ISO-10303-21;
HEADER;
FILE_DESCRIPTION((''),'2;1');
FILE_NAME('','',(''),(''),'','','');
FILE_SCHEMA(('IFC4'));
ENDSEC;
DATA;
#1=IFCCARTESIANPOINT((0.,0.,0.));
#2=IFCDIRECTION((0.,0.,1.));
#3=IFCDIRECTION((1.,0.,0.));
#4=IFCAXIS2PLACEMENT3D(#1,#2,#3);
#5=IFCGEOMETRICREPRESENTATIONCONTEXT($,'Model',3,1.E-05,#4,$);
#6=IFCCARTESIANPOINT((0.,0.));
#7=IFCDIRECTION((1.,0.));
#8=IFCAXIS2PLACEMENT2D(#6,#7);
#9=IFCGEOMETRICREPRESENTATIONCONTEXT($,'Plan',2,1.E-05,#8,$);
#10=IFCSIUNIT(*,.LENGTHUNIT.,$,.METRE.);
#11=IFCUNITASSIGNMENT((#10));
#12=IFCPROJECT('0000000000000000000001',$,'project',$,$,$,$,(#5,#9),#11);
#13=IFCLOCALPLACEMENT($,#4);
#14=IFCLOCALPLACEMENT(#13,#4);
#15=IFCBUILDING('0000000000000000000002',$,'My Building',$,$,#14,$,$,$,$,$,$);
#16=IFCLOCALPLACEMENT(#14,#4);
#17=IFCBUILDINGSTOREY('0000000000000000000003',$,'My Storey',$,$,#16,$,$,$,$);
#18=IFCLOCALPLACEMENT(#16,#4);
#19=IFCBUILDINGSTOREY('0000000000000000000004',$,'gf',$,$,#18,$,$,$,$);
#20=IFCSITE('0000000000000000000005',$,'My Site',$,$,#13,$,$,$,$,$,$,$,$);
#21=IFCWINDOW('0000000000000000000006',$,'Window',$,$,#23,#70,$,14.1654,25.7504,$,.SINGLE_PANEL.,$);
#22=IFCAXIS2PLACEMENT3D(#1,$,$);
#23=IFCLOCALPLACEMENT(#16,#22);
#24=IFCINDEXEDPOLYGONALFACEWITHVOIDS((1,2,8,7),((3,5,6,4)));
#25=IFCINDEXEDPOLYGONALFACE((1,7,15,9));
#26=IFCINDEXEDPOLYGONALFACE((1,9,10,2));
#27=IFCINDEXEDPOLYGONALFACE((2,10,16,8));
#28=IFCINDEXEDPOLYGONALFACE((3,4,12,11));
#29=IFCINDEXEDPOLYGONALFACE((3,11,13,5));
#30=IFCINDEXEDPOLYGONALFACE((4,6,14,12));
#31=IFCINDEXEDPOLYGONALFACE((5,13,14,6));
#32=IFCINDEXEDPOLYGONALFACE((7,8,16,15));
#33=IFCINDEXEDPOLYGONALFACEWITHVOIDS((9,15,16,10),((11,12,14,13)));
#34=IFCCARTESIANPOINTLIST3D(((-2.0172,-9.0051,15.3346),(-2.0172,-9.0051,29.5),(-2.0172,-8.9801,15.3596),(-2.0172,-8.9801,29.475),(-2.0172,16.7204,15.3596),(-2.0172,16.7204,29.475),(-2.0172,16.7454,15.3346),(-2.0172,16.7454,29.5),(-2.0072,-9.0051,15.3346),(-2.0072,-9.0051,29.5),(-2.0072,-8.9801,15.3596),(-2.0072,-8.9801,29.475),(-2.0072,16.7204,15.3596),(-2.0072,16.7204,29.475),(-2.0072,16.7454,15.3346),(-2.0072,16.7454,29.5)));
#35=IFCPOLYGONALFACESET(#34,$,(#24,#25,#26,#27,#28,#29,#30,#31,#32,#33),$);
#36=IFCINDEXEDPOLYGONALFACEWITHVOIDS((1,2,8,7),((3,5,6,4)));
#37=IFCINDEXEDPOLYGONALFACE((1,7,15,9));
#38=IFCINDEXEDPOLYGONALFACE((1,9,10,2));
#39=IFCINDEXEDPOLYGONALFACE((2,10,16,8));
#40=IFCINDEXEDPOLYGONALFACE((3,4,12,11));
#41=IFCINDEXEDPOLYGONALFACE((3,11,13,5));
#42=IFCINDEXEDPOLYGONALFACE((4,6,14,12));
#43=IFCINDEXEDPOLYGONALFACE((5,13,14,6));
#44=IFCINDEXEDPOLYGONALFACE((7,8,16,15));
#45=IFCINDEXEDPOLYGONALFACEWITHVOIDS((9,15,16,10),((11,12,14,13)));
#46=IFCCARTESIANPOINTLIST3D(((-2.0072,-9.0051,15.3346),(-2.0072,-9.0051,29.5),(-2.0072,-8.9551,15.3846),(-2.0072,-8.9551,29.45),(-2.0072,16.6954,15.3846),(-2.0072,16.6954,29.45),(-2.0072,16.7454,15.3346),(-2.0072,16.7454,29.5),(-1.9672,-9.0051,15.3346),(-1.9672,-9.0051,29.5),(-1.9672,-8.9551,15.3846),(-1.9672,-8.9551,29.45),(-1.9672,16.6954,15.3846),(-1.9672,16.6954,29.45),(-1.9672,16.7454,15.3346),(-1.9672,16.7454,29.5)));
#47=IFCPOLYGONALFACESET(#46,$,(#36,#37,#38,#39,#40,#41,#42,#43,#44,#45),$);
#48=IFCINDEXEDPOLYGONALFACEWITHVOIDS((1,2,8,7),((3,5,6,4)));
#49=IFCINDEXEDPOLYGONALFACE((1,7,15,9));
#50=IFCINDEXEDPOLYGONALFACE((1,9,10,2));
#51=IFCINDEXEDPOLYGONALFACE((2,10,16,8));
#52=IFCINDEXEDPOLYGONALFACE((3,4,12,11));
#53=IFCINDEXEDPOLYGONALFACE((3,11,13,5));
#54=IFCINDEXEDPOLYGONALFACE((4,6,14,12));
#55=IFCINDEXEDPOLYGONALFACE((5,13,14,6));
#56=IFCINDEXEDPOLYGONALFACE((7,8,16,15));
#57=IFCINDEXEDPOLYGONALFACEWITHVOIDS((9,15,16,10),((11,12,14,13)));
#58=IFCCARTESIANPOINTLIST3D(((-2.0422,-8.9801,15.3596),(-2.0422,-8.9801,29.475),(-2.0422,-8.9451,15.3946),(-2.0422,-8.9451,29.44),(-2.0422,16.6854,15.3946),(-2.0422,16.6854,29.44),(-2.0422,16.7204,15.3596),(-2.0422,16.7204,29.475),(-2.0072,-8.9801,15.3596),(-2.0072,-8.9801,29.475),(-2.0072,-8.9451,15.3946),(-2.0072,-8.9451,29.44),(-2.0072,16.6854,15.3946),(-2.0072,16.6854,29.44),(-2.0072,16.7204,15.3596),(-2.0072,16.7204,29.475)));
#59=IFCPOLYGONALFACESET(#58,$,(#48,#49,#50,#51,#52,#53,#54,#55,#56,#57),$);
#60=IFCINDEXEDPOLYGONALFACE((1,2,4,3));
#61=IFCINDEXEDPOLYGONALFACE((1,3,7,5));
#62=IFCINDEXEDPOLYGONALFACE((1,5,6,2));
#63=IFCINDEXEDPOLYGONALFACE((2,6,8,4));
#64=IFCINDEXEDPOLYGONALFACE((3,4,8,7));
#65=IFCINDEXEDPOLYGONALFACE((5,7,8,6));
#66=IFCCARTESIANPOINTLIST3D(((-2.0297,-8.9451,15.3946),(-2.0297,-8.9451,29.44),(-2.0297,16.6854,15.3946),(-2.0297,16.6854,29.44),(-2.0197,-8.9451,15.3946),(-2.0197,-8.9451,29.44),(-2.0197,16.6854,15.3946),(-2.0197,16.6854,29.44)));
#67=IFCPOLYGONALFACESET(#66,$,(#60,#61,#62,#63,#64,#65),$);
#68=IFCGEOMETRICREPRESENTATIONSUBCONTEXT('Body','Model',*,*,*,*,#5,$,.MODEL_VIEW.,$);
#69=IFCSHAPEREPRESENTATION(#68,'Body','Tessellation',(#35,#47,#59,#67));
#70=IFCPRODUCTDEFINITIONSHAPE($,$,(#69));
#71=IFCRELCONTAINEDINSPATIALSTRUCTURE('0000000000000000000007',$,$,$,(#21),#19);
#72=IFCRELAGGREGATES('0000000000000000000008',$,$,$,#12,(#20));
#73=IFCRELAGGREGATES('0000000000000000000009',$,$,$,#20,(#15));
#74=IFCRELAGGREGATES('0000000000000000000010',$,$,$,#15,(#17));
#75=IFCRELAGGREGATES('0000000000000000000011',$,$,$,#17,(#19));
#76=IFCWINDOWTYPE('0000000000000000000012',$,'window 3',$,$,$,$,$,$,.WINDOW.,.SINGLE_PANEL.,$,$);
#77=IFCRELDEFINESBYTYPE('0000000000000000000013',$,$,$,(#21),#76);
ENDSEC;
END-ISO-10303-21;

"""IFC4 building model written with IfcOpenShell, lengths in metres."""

from ifc_helpers import new_model, entity, si_unit, frame, origin_with_axes, origin_2d_with_axis, place, context, subcontext, project, spatial, line, indexed_curve, outline, extrude, shape, source, transform, mapped, type_object, type_shapes, element, save


model = new_model("IFC4")

# Units and contexts
model_context = context("Model", 3, precision=1e-05, world=origin_with_axes())
plan_context = context("Plan", 2, precision=1e-05, world=origin_2d_with_axis())
body_context_1 = subcontext(model_context, "Body", "Model", "MODEL_VIEW")
body_context_2 = subcontext(plan_context, "Body", "Plan", "PLAN_VIEW")
ifc_project = project(units=[si_unit("LENGTHUNIT", "METRE")], contexts=[model_context, plan_context])

# Site, building, storeys
site_placement = place(None, origin_with_axes())
site = spatial("IfcSite", under=ifc_project, at=site_placement, Name="My Site")
building_placement = place(site_placement, origin_with_axes())
building = spatial("IfcBuilding", under=site, at=building_placement, Name="My Building")
storey_1_placement = place(building_placement, origin_with_axes())
storey_1 = spatial("IfcBuildingStorey", under=building, at=storey_1_placement, Name="My Storey")
storey_2_placement = place(storey_1_placement, origin_with_axes())
storey_2 = spatial("IfcBuildingStorey", under=storey_1, at=storey_2_placement, Name="gf")

# Window
window_type_1 = type_object("IfcWindowType", Name="window 3", PartitioningType="SINGLE_PANEL", PredefinedType="WINDOW")
shared_shape_1 = source(origin_with_axes(), body_context_1, "Body", "SweptSolid", [
    extrude(outline(indexed_curve([(0.0, 0.0), (25.7504, 0.0), (25.7504, 14.1654), (0.0, 14.1654)], segments=[line(1, 2, 3, 4, 1)]), holes=[indexed_curve([(0.025, 0.025), (25.7254, 0.025), (25.7254, 14.1404), (0.025, 14.1404)], segments=[line(1, 2, 3, 4, 1)])]), frame((0.0, 0.09, 0.0), z_axis=(0.0, -1.0, 0.0), x_axis=(1.0, 0.0, 0.0)), (0.0, 0.0, -1.0), 0.01),
    extrude(outline(indexed_curve([(0.0, 0.0), (25.7504, 0.0), (25.7504, 14.1654), (0.0, 14.1654)], segments=[line(1, 2, 3, 4, 1)]), holes=[indexed_curve([(0.05, 0.05), (25.7004, 0.05), (25.7004, 14.1154), (0.05, 14.1154)], segments=[line(1, 2, 3, 4, 1)])]), frame((0.0, 0.05, 0.0), z_axis=(0.0, -1.0, 0.0), x_axis=(1.0, 0.0, 0.0)), (0.0, 0.0, -1.0), 0.04),
    extrude(outline(indexed_curve([(0.0, 0.0), (25.7004, 0.0), (25.7004, 14.1154), (0.0, 14.1154)], segments=[line(1, 2, 3, 4, 1)]), holes=[indexed_curve([(0.035, 0.035), (25.6654, 0.035), (25.6654, 14.0804), (0.035, 14.0804)], segments=[line(1, 2, 3, 4, 1)])]), frame((0.025, 0.09, 0.025), z_axis=(0.0, -1.0, 0.0), x_axis=(1.0, 0.0, 0.0)), (0.0, 0.0, -1.0), 0.035),
    extrude(outline(indexed_curve([(0.035, 0.035), (25.6654, 0.035), (25.6654, 14.0804), (0.035, 14.0804)], segments=[line(1, 2, 3, 4, 1)])), frame((0.025, 0.1025, 0.025), z_axis=(0.0, -1.0, 0.0), x_axis=(1.0, 0.0, 0.0)), (0.0, 0.0, -1.0), 0.01),
])
shared_shape_2 = source(origin_with_axes(), body_context_2, "Body", "Curve2D", [
    entity("IfcIndexedPolyCurve", entity("IfcCartesianPointList2D", [[0.05, 0.05], [25.7004, 0.05]])),
    entity("IfcIndexedPolyCurve", entity("IfcCartesianPointList2D", [[0.0, 0.1], [0.025, 0.1], [0.025, 0.09], [0.05, 0.09], [0.05, 0.05], [0.0, 0.05]]), [entity("IfcLineIndex", [1, 2, 3, 4, 5, 6, 1])]),
    entity("IfcIndexedPolyCurve", entity("IfcCartesianPointList2D", [[25.7504, 0.1], [25.7254, 0.1], [25.7254, 0.09], [25.7004, 0.09], [25.7004, 0.05], [25.7504, 0.05]]), [entity("IfcLineIndex", [1, 2, 3, 4, 5, 6, 1])]),
    entity("IfcIndexedPolyCurve", entity("IfcCartesianPointList2D", [[0.025, 0.09], [0.06, 0.09], [0.06, 0.125], [0.025, 0.125]]), [entity("IfcLineIndex", [1, 2, 3, 4, 1])]),
    entity("IfcIndexedPolyCurve", entity("IfcCartesianPointList2D", [[25.7254, 0.09], [25.6904, 0.09], [25.6904, 0.125], [25.7254, 0.125]]), [entity("IfcLineIndex", [1, 2, 3, 4, 1])]),
    entity("IfcIndexedPolyCurve", entity("IfcCartesianPointList2D", [[0.06, 0.09], [25.6904, 0.09]])),
    entity("IfcIndexedPolyCurve", entity("IfcCartesianPointList2D", [[0.06, 0.125], [25.6904, 0.125]])),
    entity("IfcIndexedPolyCurve", entity("IfcCartesianPointList2D", [[0.06, 0.1075], [25.6904, 0.1075]])),
])
type_shapes(window_type_1, [shared_shape_1, shared_shape_2])
window_placement = place(storey_2_placement, frame((-1.9172, -9.0051, 15.3346), z_axis=(0.0, 0.0, 1.0), x_axis=(0.0, 1.0, 0.0)))
element("IfcWindow", 1, at=window_placement, inside=storey_2, type_object=window_type_1, Name="Window", OverallHeight=14.1654, OverallWidth=25.7504, PartitioningType="SINGLE_PANEL", shapes=[
    shape(body_context_1, "Body", "MappedRepresentation", [mapped(shared_shape_1, transform((0.0, 0.0, 0.0), x_axis=(1.0, 0.0, 0.0), y_axis=(0.0, 1.0, 0.0), z_axis=(0.0, 0.0, 1.0), scale=1.0))]),
    shape(body_context_2, "Body", "MappedRepresentation", [mapped(shared_shape_2, transform((0.0, 0.0, 0.0), x_axis=(1.0, 0.0, 0.0), y_axis=(0.0, 1.0, 0.0), z_axis=(0.0, 0.0, 1.0), scale=1.0))]),
])

save(model, "model.ifc")
